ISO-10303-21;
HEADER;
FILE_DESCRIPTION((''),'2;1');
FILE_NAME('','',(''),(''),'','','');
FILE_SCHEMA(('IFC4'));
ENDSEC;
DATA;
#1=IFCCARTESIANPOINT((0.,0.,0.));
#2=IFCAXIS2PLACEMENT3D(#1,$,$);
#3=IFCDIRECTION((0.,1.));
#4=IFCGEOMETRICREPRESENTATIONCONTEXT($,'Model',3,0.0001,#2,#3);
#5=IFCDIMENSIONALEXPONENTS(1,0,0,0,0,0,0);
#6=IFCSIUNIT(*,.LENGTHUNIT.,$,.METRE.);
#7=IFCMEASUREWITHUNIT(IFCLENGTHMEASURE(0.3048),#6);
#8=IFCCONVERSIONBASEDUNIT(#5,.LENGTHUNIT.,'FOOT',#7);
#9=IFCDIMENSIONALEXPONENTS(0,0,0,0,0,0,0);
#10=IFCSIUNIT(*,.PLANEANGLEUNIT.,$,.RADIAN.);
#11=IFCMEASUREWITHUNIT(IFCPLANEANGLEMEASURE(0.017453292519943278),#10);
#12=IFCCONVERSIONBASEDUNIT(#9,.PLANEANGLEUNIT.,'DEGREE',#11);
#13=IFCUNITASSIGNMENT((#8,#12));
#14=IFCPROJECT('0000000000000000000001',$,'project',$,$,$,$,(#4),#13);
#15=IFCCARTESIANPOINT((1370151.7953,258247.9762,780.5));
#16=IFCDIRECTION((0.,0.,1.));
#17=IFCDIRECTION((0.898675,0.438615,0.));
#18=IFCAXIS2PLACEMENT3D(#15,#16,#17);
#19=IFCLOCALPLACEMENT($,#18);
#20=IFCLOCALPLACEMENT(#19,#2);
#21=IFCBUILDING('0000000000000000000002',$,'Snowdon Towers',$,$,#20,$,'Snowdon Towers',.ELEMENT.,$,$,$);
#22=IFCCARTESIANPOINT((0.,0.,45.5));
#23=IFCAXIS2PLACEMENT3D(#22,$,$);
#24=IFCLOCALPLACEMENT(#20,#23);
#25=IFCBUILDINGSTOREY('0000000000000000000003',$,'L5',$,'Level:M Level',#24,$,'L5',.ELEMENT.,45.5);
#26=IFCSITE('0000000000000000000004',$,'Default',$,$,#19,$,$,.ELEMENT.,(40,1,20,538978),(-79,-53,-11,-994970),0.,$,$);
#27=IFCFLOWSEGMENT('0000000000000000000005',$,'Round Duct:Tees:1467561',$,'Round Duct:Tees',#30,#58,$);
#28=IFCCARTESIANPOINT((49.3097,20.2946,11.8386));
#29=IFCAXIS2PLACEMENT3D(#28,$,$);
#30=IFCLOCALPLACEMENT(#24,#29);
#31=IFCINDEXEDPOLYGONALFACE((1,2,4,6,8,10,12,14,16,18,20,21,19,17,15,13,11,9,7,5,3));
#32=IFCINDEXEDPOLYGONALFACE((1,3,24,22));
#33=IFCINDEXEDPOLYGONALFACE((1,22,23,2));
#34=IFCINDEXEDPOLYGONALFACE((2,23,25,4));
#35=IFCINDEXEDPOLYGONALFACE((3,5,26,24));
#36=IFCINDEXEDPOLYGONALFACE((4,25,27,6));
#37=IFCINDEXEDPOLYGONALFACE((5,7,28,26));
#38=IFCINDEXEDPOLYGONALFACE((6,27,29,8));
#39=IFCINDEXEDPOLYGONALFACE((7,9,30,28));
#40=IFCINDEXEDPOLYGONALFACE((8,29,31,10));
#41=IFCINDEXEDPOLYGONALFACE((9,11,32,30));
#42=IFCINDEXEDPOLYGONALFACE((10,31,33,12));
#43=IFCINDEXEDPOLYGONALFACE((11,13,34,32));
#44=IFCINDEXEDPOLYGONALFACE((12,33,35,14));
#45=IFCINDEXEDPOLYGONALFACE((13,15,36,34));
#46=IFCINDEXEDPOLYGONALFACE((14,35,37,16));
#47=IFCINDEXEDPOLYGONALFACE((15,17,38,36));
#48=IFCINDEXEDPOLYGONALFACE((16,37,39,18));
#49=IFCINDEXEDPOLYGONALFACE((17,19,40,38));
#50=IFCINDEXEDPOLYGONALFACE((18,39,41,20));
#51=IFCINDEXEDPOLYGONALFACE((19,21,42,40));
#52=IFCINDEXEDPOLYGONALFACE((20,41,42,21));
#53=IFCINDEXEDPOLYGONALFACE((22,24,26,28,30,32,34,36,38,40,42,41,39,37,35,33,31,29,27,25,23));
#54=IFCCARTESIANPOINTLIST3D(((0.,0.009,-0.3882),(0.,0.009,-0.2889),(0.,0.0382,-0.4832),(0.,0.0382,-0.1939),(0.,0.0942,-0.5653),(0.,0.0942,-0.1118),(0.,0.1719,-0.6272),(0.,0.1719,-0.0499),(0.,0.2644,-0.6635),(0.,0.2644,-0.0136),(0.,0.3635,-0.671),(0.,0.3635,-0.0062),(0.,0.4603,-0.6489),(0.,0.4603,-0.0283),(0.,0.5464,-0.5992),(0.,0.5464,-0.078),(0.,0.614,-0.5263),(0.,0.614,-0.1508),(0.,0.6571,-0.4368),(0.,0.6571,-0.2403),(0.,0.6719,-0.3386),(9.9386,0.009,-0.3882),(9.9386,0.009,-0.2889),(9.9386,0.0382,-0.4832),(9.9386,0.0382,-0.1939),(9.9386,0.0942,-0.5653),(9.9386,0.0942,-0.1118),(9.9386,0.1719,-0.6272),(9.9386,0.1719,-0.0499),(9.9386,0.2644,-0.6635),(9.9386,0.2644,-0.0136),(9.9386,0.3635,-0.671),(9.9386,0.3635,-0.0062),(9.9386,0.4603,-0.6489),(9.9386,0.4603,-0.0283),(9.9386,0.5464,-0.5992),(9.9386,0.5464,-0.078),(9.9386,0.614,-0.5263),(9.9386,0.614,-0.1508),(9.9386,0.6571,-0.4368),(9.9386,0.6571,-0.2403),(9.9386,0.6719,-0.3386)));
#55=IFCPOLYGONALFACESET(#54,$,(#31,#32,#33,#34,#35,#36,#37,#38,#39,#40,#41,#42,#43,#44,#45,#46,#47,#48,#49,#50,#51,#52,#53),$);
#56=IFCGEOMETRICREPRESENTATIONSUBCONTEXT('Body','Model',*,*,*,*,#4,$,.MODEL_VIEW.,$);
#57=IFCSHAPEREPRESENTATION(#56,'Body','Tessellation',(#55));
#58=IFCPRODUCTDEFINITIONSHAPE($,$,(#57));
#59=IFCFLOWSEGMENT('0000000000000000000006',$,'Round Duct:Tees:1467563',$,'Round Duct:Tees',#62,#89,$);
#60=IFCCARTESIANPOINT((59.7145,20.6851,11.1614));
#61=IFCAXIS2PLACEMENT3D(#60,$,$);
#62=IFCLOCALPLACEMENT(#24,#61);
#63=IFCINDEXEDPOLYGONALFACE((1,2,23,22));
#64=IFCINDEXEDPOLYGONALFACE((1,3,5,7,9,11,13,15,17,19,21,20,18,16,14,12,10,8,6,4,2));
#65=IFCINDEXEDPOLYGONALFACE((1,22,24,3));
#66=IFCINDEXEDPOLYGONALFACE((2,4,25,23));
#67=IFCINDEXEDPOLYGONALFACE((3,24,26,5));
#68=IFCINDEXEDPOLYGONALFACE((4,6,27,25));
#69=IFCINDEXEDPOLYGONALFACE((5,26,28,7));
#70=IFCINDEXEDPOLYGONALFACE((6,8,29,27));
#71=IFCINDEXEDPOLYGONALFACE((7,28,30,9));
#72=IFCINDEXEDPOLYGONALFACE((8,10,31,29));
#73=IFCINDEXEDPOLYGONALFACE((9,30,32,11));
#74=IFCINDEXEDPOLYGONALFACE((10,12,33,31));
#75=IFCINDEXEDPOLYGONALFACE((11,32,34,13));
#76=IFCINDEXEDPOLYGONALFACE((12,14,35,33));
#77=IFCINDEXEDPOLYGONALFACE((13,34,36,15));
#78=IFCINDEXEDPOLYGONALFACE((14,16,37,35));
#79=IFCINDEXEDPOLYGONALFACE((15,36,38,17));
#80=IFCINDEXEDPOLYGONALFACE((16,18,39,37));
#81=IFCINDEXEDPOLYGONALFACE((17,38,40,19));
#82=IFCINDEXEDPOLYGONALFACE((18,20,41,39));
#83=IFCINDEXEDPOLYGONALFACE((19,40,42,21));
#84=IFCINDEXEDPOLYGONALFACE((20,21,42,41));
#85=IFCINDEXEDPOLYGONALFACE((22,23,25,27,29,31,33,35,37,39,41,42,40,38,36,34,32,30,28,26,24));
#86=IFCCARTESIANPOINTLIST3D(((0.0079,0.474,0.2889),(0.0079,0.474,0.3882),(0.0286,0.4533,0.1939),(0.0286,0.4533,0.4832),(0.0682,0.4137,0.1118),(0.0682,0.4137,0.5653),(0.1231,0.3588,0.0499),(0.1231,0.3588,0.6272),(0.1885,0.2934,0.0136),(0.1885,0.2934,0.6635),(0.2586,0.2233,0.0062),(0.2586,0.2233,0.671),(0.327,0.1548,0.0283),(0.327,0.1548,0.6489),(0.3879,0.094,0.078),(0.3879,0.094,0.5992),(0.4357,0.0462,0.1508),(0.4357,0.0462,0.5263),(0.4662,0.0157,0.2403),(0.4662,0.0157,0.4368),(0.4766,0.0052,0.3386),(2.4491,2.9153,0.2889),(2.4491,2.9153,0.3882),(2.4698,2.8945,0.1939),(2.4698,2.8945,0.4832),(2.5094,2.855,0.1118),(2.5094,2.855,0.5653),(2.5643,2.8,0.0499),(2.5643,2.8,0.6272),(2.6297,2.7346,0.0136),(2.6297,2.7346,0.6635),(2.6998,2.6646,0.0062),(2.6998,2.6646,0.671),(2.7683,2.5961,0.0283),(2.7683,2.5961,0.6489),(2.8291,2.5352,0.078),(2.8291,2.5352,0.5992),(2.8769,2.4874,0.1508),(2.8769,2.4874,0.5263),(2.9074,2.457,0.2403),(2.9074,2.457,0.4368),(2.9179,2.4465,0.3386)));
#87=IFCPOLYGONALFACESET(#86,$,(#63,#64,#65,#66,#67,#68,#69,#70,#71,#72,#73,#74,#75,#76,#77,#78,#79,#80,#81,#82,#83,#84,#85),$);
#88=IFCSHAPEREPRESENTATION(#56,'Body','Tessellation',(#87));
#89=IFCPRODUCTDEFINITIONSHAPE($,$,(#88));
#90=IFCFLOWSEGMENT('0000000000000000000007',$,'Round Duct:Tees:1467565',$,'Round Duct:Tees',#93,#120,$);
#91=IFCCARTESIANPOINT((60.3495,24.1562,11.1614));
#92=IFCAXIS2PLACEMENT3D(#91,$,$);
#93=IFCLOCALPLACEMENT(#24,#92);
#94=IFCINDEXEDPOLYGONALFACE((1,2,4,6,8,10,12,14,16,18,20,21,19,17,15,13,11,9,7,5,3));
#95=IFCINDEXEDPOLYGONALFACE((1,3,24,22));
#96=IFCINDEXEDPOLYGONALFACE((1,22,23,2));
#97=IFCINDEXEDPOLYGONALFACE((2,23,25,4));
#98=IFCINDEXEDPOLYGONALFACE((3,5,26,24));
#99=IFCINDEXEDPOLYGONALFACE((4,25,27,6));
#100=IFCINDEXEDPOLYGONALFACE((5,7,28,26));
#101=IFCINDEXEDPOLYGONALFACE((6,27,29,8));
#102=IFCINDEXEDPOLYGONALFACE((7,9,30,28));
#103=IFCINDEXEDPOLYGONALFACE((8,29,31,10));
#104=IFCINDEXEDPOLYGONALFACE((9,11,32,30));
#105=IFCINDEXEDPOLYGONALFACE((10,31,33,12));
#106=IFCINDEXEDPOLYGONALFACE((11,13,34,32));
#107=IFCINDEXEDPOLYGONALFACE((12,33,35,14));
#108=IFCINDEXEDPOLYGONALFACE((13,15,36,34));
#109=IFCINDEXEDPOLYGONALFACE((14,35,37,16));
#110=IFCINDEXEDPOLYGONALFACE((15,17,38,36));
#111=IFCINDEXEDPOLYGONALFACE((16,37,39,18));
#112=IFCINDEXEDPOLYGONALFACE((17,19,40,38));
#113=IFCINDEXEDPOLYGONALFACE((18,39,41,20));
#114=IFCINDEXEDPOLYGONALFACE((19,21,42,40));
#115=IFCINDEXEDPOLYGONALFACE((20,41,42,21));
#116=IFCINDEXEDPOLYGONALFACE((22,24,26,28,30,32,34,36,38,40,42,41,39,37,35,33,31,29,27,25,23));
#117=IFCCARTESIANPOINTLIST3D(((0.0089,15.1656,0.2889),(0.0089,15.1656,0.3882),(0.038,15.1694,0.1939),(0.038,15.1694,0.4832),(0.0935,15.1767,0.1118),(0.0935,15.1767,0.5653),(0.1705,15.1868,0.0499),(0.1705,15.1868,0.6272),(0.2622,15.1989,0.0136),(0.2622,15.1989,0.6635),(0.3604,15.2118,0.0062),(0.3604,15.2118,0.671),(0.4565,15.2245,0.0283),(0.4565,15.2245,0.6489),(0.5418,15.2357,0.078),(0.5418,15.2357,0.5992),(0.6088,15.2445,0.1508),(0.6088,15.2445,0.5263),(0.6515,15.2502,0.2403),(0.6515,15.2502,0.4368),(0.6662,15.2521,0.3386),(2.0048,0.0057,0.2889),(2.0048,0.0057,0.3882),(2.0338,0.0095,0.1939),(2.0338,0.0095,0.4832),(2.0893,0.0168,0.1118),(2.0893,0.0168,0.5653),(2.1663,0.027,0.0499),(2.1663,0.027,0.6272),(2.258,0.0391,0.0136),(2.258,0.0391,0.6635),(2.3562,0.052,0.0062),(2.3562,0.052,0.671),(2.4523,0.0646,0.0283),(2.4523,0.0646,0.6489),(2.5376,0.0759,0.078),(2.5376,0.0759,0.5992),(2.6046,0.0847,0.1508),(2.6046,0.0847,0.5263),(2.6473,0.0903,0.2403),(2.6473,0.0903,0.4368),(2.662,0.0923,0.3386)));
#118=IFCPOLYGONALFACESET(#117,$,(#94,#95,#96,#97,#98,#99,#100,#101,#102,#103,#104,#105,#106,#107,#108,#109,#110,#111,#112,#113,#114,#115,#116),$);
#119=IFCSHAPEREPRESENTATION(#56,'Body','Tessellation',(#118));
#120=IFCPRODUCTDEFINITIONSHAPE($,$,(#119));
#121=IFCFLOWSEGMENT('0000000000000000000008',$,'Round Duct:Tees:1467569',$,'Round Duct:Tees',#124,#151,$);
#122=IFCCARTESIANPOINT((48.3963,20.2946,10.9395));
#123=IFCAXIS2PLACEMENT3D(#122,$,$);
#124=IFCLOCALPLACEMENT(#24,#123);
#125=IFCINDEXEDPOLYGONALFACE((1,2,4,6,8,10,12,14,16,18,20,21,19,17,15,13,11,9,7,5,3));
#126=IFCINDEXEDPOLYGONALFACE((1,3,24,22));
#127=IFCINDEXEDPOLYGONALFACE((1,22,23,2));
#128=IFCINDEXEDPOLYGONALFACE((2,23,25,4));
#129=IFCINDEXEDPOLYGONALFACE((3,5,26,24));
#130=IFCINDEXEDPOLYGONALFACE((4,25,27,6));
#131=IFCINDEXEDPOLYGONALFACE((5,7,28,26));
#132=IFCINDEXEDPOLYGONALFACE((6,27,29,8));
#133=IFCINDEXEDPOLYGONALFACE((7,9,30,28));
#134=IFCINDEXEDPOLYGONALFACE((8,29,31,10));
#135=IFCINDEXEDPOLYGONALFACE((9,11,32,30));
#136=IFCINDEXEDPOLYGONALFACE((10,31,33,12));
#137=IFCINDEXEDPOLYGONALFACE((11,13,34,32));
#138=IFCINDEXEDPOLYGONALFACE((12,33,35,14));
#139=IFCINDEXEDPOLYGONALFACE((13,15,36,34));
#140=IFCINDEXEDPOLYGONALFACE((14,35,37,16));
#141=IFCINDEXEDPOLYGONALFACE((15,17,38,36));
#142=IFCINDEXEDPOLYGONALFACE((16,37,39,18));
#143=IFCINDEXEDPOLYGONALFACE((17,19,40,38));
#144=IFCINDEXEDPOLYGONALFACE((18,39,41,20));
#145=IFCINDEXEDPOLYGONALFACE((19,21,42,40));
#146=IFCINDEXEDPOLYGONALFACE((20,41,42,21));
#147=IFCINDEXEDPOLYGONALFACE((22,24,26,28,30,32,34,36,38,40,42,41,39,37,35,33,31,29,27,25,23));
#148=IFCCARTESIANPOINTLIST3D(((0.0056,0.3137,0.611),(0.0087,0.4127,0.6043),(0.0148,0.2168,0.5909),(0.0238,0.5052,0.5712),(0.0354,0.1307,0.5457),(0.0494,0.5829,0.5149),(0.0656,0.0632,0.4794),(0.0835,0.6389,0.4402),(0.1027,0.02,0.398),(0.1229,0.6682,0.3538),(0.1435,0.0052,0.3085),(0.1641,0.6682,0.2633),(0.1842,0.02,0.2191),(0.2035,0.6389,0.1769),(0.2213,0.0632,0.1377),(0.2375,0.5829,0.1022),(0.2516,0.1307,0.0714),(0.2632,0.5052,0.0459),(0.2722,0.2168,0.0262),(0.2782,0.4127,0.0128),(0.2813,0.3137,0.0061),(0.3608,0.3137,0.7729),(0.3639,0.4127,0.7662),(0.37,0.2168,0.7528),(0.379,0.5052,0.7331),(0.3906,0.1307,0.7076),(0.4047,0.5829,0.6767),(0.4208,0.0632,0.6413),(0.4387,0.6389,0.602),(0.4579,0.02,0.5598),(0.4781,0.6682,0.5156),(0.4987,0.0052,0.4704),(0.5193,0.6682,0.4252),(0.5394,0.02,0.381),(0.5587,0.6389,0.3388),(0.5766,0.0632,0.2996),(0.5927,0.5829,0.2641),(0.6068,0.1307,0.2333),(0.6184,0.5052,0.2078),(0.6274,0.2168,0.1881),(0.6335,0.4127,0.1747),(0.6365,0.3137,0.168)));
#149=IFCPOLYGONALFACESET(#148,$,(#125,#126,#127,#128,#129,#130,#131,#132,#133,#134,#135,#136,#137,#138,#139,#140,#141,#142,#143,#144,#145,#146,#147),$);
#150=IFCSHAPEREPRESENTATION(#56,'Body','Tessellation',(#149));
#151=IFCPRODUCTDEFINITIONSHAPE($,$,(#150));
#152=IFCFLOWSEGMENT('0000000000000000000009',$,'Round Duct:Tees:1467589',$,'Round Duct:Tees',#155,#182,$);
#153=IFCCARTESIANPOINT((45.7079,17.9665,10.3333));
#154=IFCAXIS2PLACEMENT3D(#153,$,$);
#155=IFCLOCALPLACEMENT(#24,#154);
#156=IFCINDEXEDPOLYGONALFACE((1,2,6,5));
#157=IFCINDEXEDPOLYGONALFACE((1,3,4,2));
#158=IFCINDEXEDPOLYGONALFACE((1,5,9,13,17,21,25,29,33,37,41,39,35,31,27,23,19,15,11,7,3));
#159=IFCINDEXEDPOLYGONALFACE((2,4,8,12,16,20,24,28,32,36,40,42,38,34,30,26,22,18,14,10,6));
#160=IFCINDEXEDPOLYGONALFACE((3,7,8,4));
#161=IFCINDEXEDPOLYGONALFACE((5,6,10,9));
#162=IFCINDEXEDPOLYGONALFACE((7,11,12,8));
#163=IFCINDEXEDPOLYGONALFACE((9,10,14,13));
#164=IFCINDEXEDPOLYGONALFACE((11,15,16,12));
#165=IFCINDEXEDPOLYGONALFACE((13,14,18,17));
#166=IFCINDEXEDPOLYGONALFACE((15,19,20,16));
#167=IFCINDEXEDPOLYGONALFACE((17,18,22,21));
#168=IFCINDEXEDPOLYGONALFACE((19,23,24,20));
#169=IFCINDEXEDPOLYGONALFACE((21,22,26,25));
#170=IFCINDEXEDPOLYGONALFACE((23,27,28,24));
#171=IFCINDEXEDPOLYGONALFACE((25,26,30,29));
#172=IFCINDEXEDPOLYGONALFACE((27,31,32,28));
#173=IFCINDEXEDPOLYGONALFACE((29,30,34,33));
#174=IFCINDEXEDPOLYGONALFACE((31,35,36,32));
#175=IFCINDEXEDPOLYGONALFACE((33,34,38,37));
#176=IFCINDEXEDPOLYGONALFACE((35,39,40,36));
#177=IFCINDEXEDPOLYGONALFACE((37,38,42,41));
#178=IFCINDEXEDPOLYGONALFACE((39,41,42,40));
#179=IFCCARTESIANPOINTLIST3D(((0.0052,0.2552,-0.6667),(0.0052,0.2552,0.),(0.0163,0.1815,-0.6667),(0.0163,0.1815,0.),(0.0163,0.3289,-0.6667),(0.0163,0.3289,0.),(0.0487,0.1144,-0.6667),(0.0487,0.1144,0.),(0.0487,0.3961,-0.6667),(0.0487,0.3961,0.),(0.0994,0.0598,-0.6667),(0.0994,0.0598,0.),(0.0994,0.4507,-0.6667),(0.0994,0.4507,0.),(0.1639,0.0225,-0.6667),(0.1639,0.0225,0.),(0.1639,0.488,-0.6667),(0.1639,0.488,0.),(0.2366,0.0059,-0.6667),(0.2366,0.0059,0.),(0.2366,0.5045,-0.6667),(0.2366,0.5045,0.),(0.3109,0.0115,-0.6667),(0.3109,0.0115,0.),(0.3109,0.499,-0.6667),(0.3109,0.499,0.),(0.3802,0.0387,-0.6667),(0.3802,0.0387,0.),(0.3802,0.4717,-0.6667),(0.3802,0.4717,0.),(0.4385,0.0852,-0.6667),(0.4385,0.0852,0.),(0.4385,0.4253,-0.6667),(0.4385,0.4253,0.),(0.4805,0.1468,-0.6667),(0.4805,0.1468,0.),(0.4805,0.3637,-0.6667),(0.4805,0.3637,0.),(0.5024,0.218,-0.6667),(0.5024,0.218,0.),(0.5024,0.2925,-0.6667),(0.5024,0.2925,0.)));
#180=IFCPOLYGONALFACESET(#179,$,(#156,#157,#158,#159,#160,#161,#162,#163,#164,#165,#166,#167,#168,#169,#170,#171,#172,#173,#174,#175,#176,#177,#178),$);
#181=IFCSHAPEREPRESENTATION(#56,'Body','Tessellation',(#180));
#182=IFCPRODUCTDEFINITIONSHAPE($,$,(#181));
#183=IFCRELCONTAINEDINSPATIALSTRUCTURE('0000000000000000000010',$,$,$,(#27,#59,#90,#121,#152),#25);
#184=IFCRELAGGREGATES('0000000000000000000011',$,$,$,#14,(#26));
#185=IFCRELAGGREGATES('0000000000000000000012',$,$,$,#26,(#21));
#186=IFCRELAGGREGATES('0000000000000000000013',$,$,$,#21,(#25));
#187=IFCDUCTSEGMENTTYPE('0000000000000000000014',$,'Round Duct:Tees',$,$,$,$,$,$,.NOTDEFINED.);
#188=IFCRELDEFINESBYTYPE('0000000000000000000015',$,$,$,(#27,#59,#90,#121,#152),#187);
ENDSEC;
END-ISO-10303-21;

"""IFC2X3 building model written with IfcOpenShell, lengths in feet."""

from ifc_helpers import new_model, entity, si_unit, converted_unit, direction, frame, frame_2d, origin, origin_2d_with_axis, place, context, subcontext, project, spatial, circle, extrude, type_object, element, save


model = new_model("IFC2X3")

# Units and contexts
model_context = context("Model", 3, precision=0.0001, world=origin(), true_north=direction((0.0, 1.0)))
body_context = subcontext(model_context, "Body", "Model", "MODEL_VIEW")
ifc_project = project(units=[converted_unit("LENGTHUNIT", "FOOT", entity("IfcLengthMeasure", 0.3048), si_unit("LENGTHUNIT", "METRE"), dimensions=[1, 0, 0, 0, 0, 0, 0]), converted_unit("PLANEANGLEUNIT", "DEGREE", entity("IfcPlaneAngleMeasure", 0.017453292519943278), si_unit("PLANEANGLEUNIT", "RADIAN"), dimensions=[0, 0, 0, 0, 0, 0, 0])], contexts=[model_context])

# Site, building, storey
site_placement = place(None, frame((1370151.7953, 258247.9762, 780.5), z_axis=(0.0, 0.0, 1.0), x_axis=(0.898675, 0.438615, 0.0)))
site = spatial("IfcSite", under=ifc_project, at=site_placement, Name="Default", CompositionType="ELEMENT", RefLatitude=(40, 1, 20, 538978), RefLongitude=(-79, -53, -11, -994970), RefElevation=0.0)
building_placement = place(site_placement, origin())
building = spatial("IfcBuilding", under=site, at=building_placement, Name="Snowdon Towers", LongName="Snowdon Towers", CompositionType="ELEMENT")
storey_placement = place(building_placement, frame((0.0, 0.0, 45.5)))
storey = spatial("IfcBuildingStorey", under=building, at=storey_placement, Name="L5", ObjectType="Level:M Level", LongName="L5", CompositionType="ELEMENT", Elevation=45.5)

# Flow segments
duct_segment_type = type_object("IfcDuctSegmentType", Name="Round Duct:Tees", PredefinedType="NOTDEFINED")
flow_segment_1_placement = place(storey_placement, frame((49.3097, 20.2946, 11.8386)))
element("IfcFlowSegment", 1, at=flow_segment_1_placement, inside=storey, type_object=duct_segment_type, Name="Round Duct:Tees:1467561", ObjectType="Round Duct:Tees", context=body_context, shape_type="SweptSolid", body=[
    extrude(circle(Radius=0.3333, at=frame_2d((0.0, 0.0), x_axis=(1.0, 0.0))), frame((0.0, 0.3386, -0.3386), z_axis=(1.0, 0.0, 0.0), x_axis=(0.0, 1.0, 0.0)), (0.0, 0.0, 1.0), 9.9386),
])
flow_segment_2_placement = place(storey_placement, frame((59.7145, 20.6851, 11.1614)))
element("IfcFlowSegment", 2, at=flow_segment_2_placement, inside=storey, type_object=duct_segment_type, Name="Round Duct:Tees:1467563", ObjectType="Round Duct:Tees", context=body_context, shape_type="SweptSolid", body=[
    extrude(circle(Radius=0.3333, at=origin_2d_with_axis()), frame((0.2409, 0.2409, 0.3386), z_axis=(0.707107, 0.707107, 0.0), x_axis=(0.707107, -0.707107, 0.0)), (0.0, 0.0, 1.0), 3.4525),
])
flow_segment_3_placement = place(storey_placement, frame((60.3495, 24.1562, 11.1614)))
element("IfcFlowSegment", 3, at=flow_segment_3_placement, inside=storey, type_object=duct_segment_type, Name="Round Duct:Tees:1467565", ObjectType="Round Duct:Tees", context=body_context, shape_type="SweptSolid", body=[
    extrude(circle(Radius=0.3333, at=frame_2d((0.0, 0.0), x_axis=(1.0, 0.0))), frame((2.3315, 0.0487, 0.3386), z_axis=(-0.130526, 0.991445, 0.0), x_axis=(0.991445, 0.130526, 0.0)), (0.0, 0.0, 1.0), 15.2907),
])
flow_segment_4_placement = place(storey_placement, frame((48.3963, 20.2946, 10.9395)))
element("IfcFlowSegment", 4, at=flow_segment_4_placement, inside=storey, type_object=duct_segment_type, Name="Round Duct:Tees:1467569", ObjectType="Round Duct:Tees", context=body_context, shape_type="SweptSolid", body=[
    extrude(circle(Radius=0.3333, at=frame_2d((0.0, 0.0), x_axis=(1.0, 0.0))), frame((0.1435, 0.3386, 0.3085), z_axis=(0.909948, 0.0, 0.414723), x_axis=(0.0, -1.0, 0.0)), (0.0, 0.0, 1.0), 0.3904),
])
flow_segment_5_placement = place(storey_placement, frame((45.7079, 17.9665, 10.3333)))
element("IfcFlowSegment", 5, at=flow_segment_5_placement, inside=storey, type_object=duct_segment_type, Name="Round Duct:Tees:1467589", ObjectType="Round Duct:Tees", context=body_context, shape_type="SweptSolid", body=[
    extrude(circle(Radius=0.25, at=frame_2d((0.0, 0.0), x_axis=(1.0, 0.0))), frame((0.2552, 0.2552, -0.6667), z_axis=(0.0, 0.0, 1.0), x_axis=(-1.0, 0.0, 0.0)), (0.0, 0.0, 1.0), 0.6667),
])

save(model, "model.ifc")
